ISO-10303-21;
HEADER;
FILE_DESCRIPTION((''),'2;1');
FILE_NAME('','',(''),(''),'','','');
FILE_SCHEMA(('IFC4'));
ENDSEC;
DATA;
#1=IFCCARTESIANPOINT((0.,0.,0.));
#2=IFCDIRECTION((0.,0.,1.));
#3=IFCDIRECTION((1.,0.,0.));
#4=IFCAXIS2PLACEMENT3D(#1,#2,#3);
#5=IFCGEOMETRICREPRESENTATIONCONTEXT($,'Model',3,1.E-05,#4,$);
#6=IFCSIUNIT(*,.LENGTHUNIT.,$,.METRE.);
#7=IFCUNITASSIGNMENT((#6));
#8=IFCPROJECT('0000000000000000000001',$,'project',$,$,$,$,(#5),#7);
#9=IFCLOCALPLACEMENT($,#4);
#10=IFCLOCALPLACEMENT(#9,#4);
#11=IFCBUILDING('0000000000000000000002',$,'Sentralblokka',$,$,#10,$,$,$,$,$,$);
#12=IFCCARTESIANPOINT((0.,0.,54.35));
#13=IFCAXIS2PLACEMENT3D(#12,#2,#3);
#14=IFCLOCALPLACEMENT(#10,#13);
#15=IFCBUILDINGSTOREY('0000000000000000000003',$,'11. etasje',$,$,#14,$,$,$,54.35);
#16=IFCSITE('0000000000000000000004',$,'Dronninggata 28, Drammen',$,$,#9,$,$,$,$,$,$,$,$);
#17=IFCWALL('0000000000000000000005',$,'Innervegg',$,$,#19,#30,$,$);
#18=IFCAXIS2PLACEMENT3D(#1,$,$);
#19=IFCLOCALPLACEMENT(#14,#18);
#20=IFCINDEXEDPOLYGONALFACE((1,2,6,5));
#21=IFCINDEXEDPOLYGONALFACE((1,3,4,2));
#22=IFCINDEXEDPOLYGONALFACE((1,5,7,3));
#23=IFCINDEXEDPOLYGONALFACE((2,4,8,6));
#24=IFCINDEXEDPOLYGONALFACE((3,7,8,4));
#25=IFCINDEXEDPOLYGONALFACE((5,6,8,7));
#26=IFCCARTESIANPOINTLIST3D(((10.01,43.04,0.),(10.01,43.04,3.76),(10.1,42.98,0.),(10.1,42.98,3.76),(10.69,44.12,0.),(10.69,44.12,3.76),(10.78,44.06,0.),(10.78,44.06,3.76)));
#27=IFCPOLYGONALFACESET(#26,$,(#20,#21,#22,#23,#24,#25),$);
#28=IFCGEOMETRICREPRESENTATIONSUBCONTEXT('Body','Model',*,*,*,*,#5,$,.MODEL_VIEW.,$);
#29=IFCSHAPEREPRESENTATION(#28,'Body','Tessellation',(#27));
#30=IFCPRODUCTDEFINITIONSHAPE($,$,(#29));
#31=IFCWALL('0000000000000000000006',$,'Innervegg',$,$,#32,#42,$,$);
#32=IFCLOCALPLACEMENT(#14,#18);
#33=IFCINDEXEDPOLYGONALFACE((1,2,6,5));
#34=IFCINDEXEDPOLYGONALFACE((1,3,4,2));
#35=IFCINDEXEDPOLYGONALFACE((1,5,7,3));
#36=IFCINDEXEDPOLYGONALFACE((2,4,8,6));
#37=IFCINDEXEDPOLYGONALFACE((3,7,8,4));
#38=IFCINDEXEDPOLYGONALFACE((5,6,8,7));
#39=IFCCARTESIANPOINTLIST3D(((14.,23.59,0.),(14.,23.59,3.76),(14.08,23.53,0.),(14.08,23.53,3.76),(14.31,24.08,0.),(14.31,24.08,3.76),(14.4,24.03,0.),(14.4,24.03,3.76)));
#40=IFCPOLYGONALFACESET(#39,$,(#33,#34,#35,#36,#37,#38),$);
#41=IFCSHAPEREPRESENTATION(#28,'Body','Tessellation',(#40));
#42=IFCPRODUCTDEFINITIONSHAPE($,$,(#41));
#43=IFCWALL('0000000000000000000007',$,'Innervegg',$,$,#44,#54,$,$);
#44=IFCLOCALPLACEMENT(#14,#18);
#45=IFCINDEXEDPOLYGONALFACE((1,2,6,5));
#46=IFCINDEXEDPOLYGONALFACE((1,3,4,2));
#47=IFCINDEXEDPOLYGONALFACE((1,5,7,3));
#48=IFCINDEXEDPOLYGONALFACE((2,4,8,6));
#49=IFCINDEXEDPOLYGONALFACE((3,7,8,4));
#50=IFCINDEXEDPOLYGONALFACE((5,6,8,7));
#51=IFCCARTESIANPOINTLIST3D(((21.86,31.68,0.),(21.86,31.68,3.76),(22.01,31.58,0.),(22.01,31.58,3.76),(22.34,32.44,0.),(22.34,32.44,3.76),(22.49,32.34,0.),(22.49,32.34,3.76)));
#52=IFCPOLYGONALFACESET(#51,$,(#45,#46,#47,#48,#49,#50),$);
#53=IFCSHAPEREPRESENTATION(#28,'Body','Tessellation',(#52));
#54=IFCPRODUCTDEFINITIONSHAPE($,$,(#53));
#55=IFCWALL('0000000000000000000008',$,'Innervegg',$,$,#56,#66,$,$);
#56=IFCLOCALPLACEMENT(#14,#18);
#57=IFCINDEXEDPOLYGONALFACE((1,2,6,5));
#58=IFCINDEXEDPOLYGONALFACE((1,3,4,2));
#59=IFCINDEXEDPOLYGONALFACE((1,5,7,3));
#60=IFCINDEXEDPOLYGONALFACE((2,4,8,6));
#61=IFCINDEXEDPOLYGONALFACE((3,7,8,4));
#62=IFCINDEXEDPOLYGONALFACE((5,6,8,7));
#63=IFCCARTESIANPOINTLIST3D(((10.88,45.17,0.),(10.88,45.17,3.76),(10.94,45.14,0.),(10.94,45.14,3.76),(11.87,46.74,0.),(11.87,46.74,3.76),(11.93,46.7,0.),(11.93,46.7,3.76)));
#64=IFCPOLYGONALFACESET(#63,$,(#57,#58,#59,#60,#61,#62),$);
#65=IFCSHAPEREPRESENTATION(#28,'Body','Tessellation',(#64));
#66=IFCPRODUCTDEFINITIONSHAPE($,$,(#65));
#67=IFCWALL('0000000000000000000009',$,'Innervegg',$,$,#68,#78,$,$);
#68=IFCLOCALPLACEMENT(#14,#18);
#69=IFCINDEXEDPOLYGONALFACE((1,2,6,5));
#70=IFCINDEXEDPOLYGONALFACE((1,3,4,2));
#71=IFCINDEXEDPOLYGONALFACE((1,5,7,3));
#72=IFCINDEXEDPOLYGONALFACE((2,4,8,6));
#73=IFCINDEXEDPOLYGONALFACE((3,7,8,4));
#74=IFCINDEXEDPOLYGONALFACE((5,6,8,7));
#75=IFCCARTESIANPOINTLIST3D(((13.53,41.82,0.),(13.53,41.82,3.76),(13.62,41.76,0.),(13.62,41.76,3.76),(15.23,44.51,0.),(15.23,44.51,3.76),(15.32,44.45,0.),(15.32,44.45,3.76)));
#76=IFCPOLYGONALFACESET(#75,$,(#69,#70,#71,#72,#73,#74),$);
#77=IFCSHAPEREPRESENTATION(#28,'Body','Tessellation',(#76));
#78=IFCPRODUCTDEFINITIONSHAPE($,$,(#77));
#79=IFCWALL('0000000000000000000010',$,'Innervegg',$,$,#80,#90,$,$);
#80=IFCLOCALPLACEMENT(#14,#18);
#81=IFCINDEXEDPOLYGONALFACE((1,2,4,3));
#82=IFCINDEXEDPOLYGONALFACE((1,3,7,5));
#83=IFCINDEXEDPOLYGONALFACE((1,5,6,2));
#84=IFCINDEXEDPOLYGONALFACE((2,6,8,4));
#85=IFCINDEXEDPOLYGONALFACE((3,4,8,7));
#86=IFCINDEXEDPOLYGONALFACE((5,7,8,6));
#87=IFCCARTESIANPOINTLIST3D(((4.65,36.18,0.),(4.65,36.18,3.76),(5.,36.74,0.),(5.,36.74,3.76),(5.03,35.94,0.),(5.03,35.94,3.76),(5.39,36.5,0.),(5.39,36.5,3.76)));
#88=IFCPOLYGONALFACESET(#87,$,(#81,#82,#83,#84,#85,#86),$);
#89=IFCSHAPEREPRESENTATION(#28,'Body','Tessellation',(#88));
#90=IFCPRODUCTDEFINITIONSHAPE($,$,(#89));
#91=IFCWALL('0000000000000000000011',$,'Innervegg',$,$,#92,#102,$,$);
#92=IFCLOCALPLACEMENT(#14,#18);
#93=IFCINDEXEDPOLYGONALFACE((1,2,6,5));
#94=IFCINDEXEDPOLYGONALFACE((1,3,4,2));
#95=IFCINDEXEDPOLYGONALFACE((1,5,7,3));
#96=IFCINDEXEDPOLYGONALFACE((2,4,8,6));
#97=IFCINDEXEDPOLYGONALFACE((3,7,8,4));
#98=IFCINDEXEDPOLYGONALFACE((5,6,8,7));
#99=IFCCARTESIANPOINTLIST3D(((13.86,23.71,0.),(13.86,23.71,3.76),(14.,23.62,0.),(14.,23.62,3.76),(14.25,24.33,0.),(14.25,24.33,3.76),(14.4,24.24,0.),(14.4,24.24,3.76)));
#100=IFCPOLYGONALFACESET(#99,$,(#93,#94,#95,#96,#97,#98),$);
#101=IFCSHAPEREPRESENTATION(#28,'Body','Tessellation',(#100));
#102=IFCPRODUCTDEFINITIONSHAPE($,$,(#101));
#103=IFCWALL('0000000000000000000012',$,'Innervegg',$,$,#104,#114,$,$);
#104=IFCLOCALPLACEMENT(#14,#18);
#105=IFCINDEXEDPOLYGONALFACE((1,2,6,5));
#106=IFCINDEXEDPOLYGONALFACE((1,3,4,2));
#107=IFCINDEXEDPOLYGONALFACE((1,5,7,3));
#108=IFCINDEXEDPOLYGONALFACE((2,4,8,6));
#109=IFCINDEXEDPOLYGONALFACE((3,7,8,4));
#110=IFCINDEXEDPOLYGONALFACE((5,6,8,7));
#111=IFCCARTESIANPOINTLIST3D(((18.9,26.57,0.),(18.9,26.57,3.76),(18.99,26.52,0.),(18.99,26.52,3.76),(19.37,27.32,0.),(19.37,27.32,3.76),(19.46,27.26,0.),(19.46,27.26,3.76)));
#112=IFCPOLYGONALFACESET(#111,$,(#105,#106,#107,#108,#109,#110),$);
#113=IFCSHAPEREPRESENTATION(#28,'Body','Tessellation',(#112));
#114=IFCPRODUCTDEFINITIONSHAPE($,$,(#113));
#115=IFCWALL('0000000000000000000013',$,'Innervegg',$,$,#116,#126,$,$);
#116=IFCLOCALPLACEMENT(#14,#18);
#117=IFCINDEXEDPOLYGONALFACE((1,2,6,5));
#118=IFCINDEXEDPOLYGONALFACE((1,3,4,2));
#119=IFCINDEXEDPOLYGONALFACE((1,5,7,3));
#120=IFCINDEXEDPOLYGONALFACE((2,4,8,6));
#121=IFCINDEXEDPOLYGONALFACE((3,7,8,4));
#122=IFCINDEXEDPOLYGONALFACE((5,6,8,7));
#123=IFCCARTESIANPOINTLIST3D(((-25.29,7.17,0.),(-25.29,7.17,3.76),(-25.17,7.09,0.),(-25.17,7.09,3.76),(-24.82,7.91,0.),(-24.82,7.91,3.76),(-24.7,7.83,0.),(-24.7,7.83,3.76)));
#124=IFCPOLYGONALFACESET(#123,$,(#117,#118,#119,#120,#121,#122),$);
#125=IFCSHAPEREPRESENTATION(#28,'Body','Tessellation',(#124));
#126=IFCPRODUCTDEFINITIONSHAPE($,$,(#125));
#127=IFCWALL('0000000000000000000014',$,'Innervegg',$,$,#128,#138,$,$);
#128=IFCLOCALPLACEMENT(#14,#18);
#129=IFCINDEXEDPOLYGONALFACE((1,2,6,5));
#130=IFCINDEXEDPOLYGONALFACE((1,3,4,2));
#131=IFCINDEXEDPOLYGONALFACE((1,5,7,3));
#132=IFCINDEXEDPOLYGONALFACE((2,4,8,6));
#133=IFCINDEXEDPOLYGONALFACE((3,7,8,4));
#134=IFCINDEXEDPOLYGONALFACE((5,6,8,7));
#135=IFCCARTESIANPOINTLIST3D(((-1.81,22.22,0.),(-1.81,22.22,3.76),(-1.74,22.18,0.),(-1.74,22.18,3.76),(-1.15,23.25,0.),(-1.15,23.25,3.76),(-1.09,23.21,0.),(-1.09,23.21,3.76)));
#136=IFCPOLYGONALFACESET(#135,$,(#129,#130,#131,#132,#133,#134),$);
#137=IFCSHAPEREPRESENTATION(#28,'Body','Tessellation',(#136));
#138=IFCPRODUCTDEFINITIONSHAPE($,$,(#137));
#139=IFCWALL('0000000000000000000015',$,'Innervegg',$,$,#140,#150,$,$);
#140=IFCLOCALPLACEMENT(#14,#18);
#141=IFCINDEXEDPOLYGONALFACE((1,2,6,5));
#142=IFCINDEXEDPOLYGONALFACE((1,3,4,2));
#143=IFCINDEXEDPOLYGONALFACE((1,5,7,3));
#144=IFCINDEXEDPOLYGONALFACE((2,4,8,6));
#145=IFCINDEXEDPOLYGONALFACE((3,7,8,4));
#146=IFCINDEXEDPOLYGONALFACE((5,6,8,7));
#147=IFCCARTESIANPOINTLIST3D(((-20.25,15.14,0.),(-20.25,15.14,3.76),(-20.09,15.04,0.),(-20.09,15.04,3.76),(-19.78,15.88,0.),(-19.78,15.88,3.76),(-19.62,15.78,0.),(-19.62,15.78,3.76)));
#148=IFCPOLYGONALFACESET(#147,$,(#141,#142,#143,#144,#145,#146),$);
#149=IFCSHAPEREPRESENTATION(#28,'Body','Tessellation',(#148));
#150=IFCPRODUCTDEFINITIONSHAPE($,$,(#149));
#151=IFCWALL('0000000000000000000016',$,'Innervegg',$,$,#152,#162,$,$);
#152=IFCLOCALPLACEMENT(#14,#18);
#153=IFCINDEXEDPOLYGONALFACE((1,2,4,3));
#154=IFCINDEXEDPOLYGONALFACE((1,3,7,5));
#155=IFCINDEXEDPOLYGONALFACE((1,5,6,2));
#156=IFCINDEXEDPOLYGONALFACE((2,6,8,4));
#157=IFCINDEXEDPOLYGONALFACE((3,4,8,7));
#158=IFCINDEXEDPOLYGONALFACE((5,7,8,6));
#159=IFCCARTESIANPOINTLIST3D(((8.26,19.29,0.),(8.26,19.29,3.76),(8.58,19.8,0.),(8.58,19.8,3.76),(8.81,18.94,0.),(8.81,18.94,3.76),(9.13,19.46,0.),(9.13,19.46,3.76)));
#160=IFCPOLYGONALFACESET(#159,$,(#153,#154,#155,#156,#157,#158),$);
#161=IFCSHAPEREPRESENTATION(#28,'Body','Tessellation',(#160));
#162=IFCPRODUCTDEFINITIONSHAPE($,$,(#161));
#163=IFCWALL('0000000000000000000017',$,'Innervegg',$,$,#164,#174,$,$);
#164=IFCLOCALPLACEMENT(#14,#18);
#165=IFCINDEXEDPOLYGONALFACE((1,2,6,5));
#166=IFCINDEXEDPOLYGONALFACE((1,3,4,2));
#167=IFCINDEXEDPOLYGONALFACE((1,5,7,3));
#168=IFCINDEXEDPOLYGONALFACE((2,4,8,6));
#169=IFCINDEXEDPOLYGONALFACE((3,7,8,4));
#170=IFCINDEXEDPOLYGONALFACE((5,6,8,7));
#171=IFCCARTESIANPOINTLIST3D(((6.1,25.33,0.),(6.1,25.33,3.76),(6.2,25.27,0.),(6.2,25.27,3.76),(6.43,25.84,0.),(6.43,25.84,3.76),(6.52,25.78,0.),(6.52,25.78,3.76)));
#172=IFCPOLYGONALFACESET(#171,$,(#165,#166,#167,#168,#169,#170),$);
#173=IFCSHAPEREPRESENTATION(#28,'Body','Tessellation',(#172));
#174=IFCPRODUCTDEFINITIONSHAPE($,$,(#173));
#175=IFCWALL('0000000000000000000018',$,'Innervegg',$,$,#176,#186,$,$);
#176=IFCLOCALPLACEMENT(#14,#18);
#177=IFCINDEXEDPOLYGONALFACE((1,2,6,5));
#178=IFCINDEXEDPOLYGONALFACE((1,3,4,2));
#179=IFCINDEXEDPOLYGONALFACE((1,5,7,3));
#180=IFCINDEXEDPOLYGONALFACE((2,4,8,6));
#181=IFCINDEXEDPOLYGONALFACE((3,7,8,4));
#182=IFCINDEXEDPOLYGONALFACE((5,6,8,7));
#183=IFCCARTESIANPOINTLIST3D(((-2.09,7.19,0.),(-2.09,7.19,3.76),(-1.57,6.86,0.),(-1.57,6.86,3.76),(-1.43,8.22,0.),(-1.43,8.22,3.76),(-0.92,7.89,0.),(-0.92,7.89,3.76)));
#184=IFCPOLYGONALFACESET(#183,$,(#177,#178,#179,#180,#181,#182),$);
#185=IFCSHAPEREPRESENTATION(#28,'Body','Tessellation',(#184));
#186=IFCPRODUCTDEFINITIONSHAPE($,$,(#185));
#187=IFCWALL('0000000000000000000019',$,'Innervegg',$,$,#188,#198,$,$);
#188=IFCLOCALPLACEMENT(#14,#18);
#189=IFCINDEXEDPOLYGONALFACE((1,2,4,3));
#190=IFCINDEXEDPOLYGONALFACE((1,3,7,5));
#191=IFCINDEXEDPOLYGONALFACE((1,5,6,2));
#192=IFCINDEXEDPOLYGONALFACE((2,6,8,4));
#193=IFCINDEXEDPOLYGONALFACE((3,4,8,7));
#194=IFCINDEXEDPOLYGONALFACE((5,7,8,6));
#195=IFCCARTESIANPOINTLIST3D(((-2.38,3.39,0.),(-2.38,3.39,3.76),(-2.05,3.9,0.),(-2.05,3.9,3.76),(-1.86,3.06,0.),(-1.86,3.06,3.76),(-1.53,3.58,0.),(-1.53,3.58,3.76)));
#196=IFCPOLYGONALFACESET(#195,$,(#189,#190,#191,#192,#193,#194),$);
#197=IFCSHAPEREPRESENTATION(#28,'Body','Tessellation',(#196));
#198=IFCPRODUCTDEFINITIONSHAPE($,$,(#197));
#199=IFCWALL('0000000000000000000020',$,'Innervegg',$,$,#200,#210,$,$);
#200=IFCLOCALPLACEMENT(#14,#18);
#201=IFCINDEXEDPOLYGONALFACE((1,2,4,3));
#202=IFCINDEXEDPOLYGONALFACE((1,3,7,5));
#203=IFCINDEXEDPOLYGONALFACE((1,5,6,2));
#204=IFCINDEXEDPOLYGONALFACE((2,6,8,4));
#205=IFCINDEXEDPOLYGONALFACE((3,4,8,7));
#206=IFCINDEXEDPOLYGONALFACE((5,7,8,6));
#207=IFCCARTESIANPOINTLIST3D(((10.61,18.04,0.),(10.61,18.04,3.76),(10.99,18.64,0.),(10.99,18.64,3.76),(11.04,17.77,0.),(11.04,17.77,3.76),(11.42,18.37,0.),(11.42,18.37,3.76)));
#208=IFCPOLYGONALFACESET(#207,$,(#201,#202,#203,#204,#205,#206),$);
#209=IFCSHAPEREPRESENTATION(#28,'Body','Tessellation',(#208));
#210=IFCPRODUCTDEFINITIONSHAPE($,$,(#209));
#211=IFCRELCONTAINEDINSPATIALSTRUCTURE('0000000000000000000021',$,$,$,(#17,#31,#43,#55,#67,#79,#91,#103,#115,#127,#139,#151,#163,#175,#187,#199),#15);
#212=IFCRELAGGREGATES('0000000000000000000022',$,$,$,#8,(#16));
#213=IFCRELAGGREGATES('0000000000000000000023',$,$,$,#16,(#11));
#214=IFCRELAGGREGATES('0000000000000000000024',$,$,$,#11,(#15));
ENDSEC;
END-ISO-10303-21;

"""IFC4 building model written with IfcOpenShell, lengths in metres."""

from ifc_helpers import new_model, si_unit, frame, origin_with_axes, place, context, subcontext, project, spatial, polyline, outline, extrude, element, save


model = new_model("IFC4")

# Units and contexts
model_context = context("Model", 3, precision=1e-05, world=origin_with_axes())
body_context = subcontext(model_context, "Body", "Model", "MODEL_VIEW")
ifc_project = project(units=[si_unit("LENGTHUNIT", "METRE")], contexts=[model_context])

# Site, building, storey
site_placement = place(None, origin_with_axes())
site = spatial("IfcSite", under=ifc_project, at=site_placement, Name="Dronninggata 28, Drammen")
building_placement = place(site_placement, origin_with_axes())
building = spatial("IfcBuilding", under=site, at=building_placement, Name="Sentralblokka")
storey_placement = place(building_placement, frame((0.0, 0.0, 54.35), z_axis=(0.0, 0.0, 1.0), x_axis=(1.0, 0.0, 0.0)))
storey = spatial("IfcBuildingStorey", under=building, at=storey_placement, Name="11. etasje", Elevation=54.35)

# Walls
wall_1_placement = place(storey_placement, frame((0.0, 0.0, -54.35), z_axis=(0.0, 0.0, 1.0), x_axis=(1.0, 0.0, 0.0)))
element("IfcWall", 1, at=wall_1_placement, inside=storey, Name="Innervegg", context=body_context, shape_type="SweptSolid", body=[
    extrude(outline(polyline([(10.78, 44.06), (10.1, 42.98), (10.01, 43.04), (10.69, 44.12), (10.78, 44.06)])), frame((0.0, 0.0, 54.35)), (0.0, 0.0, 1.0), 3.76),
])
wall_2_placement = place(storey_placement, frame((0.0, 0.0, -54.35), z_axis=(0.0, 0.0, 1.0), x_axis=(1.0, 0.0, 0.0)))
element("IfcWall", 2, at=wall_2_placement, inside=storey, Name="Innervegg", context=body_context, shape_type="SweptSolid", body=[
    extrude(outline(polyline([(14.4, 24.03), (14.08, 23.53), (14.0, 23.59), (14.31, 24.08), (14.4, 24.03)])), frame((0.0, 0.0, 54.35)), (0.0, 0.0, 1.0), 3.76),
])
wall_3_placement = place(storey_placement, frame((0.0, 0.0, -54.35), z_axis=(0.0, 0.0, 1.0), x_axis=(1.0, 0.0, 0.0)))
element("IfcWall", 3, at=wall_3_placement, inside=storey, Name="Innervegg", context=body_context, shape_type="SweptSolid", body=[
    extrude(outline(polyline([(22.49, 32.34), (22.01, 31.58), (21.86, 31.68), (22.34, 32.44), (22.49, 32.34)])), frame((0.0, 0.0, 54.35)), (0.0, 0.0, 1.0), 3.76),
])
wall_4_placement = place(storey_placement, frame((0.0, 0.0, -54.35), z_axis=(0.0, 0.0, 1.0), x_axis=(1.0, 0.0, 0.0)))
element("IfcWall", 4, at=wall_4_placement, inside=storey, Name="Innervegg", context=body_context, shape_type="SweptSolid", body=[
    extrude(outline(polyline([(11.93, 46.7), (10.94, 45.14), (10.88, 45.17), (11.87, 46.74), (11.93, 46.7)])), frame((0.0, 0.0, 54.35)), (0.0, 0.0, 1.0), 3.76),
])
wall_5_placement = place(storey_placement, frame((0.0, 0.0, -54.35), z_axis=(0.0, 0.0, 1.0), x_axis=(1.0, 0.0, 0.0)))
element("IfcWall", 5, at=wall_5_placement, inside=storey, Name="Innervegg", context=body_context, shape_type="SweptSolid", body=[
    extrude(outline(polyline([(15.32, 44.45), (13.62, 41.76), (13.53, 41.82), (15.23, 44.51), (15.32, 44.45)])), frame((0.0, 0.0, 54.35)), (0.0, 0.0, 1.0), 3.76),
])
wall_6_placement = place(storey_placement, frame((0.0, 0.0, -54.35), z_axis=(0.0, 0.0, 1.0), x_axis=(1.0, 0.0, 0.0)))
element("IfcWall", 6, at=wall_6_placement, inside=storey, Name="Innervegg", context=body_context, shape_type="SweptSolid", body=[
    extrude(outline(polyline([(5.39, 36.5), (5.03, 35.94), (4.65, 36.18), (5.0, 36.74), (5.39, 36.5)])), frame((0.0, 0.0, 54.35)), (0.0, 0.0, 1.0), 3.76),
])
wall_7_placement = place(storey_placement, frame((0.0, 0.0, -54.35), z_axis=(0.0, 0.0, 1.0), x_axis=(1.0, 0.0, 0.0)))
element("IfcWall", 7, at=wall_7_placement, inside=storey, Name="Innervegg", context=body_context, shape_type="SweptSolid", body=[
    extrude(outline(polyline([(14.4, 24.24), (14.0, 23.62), (13.86, 23.71), (14.25, 24.33), (14.4, 24.24)])), frame((0.0, 0.0, 54.35)), (0.0, 0.0, 1.0), 3.76),
])
wall_8_placement = place(storey_placement, frame((0.0, 0.0, -54.35), z_axis=(0.0, 0.0, 1.0), x_axis=(1.0, 0.0, 0.0)))
element("IfcWall", 8, at=wall_8_placement, inside=storey, Name="Innervegg", context=body_context, shape_type="SweptSolid", body=[
    extrude(outline(polyline([(19.46, 27.26), (18.99, 26.52), (18.9, 26.57), (19.37, 27.32), (19.46, 27.26)])), frame((0.0, 0.0, 54.35)), (0.0, 0.0, 1.0), 3.76),
])
wall_9_placement = place(storey_placement, frame((0.0, 0.0, -54.35), z_axis=(0.0, 0.0, 1.0), x_axis=(1.0, 0.0, 0.0)))
element("IfcWall", 9, at=wall_9_placement, inside=storey, Name="Innervegg", context=body_context, shape_type="SweptSolid", body=[
    extrude(outline(polyline([(-24.7, 7.83), (-25.17, 7.09), (-25.29, 7.17), (-24.82, 7.91), (-24.7, 7.83)])), frame((0.0, 0.0, 54.35)), (0.0, 0.0, 1.0), 3.76),
])
wall_10_placement = place(storey_placement, frame((0.0, 0.0, -54.35), z_axis=(0.0, 0.0, 1.0), x_axis=(1.0, 0.0, 0.0)))
element("IfcWall", 10, at=wall_10_placement, inside=storey, Name="Innervegg", context=body_context, shape_type="SweptSolid", body=[
    extrude(outline(polyline([(-1.09, 23.21), (-1.74, 22.18), (-1.81, 22.22), (-1.15, 23.25), (-1.09, 23.21)])), frame((0.0, 0.0, 54.35)), (0.0, 0.0, 1.0), 3.76),
])
wall_11_placement = place(storey_placement, frame((0.0, 0.0, -54.35), z_axis=(0.0, 0.0, 1.0), x_axis=(1.0, 0.0, 0.0)))
element("IfcWall", 11, at=wall_11_placement, inside=storey, Name="Innervegg", context=body_context, shape_type="SweptSolid", body=[
    extrude(outline(polyline([(-19.62, 15.78), (-20.09, 15.04), (-20.25, 15.14), (-19.78, 15.88), (-19.62, 15.78)])), frame((0.0, 0.0, 54.35)), (0.0, 0.0, 1.0), 3.76),
])
wall_12_placement = place(storey_placement, frame((0.0, 0.0, -54.35), z_axis=(0.0, 0.0, 1.0), x_axis=(1.0, 0.0, 0.0)))
element("IfcWall", 12, at=wall_12_placement, inside=storey, Name="Innervegg", context=body_context, shape_type="SweptSolid", body=[
    extrude(outline(polyline([(9.13, 19.46), (8.81, 18.94), (8.26, 19.29), (8.58, 19.8), (9.13, 19.46)])), frame((0.0, 0.0, 54.35)), (0.0, 0.0, 1.0), 3.76),
])
wall_13_placement = place(storey_placement, frame((0.0, 0.0, -54.35), z_axis=(0.0, 0.0, 1.0), x_axis=(1.0, 0.0, 0.0)))
element("IfcWall", 13, at=wall_13_placement, inside=storey, Name="Innervegg", context=body_context, shape_type="SweptSolid", body=[
    extrude(outline(polyline([(6.52, 25.78), (6.2, 25.27), (6.1, 25.33), (6.43, 25.84), (6.52, 25.78)])), frame((0.0, 0.0, 54.35)), (0.0, 0.0, 1.0), 3.76),
])
wall_14_placement = place(storey_placement, frame((0.0, 0.0, -54.35), z_axis=(0.0, 0.0, 1.0), x_axis=(1.0, 0.0, 0.0)))
element("IfcWall", 14, at=wall_14_placement, inside=storey, Name="Innervegg", context=body_context, shape_type="SweptSolid", body=[
    extrude(outline(polyline([(-0.92, 7.89), (-1.57, 6.86), (-2.09, 7.19), (-1.43, 8.22), (-0.92, 7.89)])), frame((0.0, 0.0, 54.35)), (0.0, 0.0, 1.0), 3.76),
])
wall_15_placement = place(storey_placement, frame((0.0, 0.0, -54.35), z_axis=(0.0, 0.0, 1.0), x_axis=(1.0, 0.0, 0.0)))
element("IfcWall", 15, at=wall_15_placement, inside=storey, Name="Innervegg", context=body_context, shape_type="SweptSolid", body=[
    extrude(outline(polyline([(-1.53, 3.58), (-1.86, 3.06), (-2.38, 3.39), (-2.05, 3.9), (-1.53, 3.58)])), frame((0.0, 0.0, 54.35)), (0.0, 0.0, 1.0), 3.76),
])
wall_16_placement = place(storey_placement, frame((0.0, 0.0, -54.35), z_axis=(0.0, 0.0, 1.0), x_axis=(1.0, 0.0, 0.0)))
element("IfcWall", 16, at=wall_16_placement, inside=storey, Name="Innervegg", context=body_context, shape_type="SweptSolid", body=[
    extrude(outline(polyline([(11.42, 18.37), (11.04, 17.77), (10.61, 18.04), (10.99, 18.64), (11.42, 18.37)])), frame((0.0, 0.0, 54.35)), (0.0, 0.0, 1.0), 3.76),
])

save(model, "model.ifc")
